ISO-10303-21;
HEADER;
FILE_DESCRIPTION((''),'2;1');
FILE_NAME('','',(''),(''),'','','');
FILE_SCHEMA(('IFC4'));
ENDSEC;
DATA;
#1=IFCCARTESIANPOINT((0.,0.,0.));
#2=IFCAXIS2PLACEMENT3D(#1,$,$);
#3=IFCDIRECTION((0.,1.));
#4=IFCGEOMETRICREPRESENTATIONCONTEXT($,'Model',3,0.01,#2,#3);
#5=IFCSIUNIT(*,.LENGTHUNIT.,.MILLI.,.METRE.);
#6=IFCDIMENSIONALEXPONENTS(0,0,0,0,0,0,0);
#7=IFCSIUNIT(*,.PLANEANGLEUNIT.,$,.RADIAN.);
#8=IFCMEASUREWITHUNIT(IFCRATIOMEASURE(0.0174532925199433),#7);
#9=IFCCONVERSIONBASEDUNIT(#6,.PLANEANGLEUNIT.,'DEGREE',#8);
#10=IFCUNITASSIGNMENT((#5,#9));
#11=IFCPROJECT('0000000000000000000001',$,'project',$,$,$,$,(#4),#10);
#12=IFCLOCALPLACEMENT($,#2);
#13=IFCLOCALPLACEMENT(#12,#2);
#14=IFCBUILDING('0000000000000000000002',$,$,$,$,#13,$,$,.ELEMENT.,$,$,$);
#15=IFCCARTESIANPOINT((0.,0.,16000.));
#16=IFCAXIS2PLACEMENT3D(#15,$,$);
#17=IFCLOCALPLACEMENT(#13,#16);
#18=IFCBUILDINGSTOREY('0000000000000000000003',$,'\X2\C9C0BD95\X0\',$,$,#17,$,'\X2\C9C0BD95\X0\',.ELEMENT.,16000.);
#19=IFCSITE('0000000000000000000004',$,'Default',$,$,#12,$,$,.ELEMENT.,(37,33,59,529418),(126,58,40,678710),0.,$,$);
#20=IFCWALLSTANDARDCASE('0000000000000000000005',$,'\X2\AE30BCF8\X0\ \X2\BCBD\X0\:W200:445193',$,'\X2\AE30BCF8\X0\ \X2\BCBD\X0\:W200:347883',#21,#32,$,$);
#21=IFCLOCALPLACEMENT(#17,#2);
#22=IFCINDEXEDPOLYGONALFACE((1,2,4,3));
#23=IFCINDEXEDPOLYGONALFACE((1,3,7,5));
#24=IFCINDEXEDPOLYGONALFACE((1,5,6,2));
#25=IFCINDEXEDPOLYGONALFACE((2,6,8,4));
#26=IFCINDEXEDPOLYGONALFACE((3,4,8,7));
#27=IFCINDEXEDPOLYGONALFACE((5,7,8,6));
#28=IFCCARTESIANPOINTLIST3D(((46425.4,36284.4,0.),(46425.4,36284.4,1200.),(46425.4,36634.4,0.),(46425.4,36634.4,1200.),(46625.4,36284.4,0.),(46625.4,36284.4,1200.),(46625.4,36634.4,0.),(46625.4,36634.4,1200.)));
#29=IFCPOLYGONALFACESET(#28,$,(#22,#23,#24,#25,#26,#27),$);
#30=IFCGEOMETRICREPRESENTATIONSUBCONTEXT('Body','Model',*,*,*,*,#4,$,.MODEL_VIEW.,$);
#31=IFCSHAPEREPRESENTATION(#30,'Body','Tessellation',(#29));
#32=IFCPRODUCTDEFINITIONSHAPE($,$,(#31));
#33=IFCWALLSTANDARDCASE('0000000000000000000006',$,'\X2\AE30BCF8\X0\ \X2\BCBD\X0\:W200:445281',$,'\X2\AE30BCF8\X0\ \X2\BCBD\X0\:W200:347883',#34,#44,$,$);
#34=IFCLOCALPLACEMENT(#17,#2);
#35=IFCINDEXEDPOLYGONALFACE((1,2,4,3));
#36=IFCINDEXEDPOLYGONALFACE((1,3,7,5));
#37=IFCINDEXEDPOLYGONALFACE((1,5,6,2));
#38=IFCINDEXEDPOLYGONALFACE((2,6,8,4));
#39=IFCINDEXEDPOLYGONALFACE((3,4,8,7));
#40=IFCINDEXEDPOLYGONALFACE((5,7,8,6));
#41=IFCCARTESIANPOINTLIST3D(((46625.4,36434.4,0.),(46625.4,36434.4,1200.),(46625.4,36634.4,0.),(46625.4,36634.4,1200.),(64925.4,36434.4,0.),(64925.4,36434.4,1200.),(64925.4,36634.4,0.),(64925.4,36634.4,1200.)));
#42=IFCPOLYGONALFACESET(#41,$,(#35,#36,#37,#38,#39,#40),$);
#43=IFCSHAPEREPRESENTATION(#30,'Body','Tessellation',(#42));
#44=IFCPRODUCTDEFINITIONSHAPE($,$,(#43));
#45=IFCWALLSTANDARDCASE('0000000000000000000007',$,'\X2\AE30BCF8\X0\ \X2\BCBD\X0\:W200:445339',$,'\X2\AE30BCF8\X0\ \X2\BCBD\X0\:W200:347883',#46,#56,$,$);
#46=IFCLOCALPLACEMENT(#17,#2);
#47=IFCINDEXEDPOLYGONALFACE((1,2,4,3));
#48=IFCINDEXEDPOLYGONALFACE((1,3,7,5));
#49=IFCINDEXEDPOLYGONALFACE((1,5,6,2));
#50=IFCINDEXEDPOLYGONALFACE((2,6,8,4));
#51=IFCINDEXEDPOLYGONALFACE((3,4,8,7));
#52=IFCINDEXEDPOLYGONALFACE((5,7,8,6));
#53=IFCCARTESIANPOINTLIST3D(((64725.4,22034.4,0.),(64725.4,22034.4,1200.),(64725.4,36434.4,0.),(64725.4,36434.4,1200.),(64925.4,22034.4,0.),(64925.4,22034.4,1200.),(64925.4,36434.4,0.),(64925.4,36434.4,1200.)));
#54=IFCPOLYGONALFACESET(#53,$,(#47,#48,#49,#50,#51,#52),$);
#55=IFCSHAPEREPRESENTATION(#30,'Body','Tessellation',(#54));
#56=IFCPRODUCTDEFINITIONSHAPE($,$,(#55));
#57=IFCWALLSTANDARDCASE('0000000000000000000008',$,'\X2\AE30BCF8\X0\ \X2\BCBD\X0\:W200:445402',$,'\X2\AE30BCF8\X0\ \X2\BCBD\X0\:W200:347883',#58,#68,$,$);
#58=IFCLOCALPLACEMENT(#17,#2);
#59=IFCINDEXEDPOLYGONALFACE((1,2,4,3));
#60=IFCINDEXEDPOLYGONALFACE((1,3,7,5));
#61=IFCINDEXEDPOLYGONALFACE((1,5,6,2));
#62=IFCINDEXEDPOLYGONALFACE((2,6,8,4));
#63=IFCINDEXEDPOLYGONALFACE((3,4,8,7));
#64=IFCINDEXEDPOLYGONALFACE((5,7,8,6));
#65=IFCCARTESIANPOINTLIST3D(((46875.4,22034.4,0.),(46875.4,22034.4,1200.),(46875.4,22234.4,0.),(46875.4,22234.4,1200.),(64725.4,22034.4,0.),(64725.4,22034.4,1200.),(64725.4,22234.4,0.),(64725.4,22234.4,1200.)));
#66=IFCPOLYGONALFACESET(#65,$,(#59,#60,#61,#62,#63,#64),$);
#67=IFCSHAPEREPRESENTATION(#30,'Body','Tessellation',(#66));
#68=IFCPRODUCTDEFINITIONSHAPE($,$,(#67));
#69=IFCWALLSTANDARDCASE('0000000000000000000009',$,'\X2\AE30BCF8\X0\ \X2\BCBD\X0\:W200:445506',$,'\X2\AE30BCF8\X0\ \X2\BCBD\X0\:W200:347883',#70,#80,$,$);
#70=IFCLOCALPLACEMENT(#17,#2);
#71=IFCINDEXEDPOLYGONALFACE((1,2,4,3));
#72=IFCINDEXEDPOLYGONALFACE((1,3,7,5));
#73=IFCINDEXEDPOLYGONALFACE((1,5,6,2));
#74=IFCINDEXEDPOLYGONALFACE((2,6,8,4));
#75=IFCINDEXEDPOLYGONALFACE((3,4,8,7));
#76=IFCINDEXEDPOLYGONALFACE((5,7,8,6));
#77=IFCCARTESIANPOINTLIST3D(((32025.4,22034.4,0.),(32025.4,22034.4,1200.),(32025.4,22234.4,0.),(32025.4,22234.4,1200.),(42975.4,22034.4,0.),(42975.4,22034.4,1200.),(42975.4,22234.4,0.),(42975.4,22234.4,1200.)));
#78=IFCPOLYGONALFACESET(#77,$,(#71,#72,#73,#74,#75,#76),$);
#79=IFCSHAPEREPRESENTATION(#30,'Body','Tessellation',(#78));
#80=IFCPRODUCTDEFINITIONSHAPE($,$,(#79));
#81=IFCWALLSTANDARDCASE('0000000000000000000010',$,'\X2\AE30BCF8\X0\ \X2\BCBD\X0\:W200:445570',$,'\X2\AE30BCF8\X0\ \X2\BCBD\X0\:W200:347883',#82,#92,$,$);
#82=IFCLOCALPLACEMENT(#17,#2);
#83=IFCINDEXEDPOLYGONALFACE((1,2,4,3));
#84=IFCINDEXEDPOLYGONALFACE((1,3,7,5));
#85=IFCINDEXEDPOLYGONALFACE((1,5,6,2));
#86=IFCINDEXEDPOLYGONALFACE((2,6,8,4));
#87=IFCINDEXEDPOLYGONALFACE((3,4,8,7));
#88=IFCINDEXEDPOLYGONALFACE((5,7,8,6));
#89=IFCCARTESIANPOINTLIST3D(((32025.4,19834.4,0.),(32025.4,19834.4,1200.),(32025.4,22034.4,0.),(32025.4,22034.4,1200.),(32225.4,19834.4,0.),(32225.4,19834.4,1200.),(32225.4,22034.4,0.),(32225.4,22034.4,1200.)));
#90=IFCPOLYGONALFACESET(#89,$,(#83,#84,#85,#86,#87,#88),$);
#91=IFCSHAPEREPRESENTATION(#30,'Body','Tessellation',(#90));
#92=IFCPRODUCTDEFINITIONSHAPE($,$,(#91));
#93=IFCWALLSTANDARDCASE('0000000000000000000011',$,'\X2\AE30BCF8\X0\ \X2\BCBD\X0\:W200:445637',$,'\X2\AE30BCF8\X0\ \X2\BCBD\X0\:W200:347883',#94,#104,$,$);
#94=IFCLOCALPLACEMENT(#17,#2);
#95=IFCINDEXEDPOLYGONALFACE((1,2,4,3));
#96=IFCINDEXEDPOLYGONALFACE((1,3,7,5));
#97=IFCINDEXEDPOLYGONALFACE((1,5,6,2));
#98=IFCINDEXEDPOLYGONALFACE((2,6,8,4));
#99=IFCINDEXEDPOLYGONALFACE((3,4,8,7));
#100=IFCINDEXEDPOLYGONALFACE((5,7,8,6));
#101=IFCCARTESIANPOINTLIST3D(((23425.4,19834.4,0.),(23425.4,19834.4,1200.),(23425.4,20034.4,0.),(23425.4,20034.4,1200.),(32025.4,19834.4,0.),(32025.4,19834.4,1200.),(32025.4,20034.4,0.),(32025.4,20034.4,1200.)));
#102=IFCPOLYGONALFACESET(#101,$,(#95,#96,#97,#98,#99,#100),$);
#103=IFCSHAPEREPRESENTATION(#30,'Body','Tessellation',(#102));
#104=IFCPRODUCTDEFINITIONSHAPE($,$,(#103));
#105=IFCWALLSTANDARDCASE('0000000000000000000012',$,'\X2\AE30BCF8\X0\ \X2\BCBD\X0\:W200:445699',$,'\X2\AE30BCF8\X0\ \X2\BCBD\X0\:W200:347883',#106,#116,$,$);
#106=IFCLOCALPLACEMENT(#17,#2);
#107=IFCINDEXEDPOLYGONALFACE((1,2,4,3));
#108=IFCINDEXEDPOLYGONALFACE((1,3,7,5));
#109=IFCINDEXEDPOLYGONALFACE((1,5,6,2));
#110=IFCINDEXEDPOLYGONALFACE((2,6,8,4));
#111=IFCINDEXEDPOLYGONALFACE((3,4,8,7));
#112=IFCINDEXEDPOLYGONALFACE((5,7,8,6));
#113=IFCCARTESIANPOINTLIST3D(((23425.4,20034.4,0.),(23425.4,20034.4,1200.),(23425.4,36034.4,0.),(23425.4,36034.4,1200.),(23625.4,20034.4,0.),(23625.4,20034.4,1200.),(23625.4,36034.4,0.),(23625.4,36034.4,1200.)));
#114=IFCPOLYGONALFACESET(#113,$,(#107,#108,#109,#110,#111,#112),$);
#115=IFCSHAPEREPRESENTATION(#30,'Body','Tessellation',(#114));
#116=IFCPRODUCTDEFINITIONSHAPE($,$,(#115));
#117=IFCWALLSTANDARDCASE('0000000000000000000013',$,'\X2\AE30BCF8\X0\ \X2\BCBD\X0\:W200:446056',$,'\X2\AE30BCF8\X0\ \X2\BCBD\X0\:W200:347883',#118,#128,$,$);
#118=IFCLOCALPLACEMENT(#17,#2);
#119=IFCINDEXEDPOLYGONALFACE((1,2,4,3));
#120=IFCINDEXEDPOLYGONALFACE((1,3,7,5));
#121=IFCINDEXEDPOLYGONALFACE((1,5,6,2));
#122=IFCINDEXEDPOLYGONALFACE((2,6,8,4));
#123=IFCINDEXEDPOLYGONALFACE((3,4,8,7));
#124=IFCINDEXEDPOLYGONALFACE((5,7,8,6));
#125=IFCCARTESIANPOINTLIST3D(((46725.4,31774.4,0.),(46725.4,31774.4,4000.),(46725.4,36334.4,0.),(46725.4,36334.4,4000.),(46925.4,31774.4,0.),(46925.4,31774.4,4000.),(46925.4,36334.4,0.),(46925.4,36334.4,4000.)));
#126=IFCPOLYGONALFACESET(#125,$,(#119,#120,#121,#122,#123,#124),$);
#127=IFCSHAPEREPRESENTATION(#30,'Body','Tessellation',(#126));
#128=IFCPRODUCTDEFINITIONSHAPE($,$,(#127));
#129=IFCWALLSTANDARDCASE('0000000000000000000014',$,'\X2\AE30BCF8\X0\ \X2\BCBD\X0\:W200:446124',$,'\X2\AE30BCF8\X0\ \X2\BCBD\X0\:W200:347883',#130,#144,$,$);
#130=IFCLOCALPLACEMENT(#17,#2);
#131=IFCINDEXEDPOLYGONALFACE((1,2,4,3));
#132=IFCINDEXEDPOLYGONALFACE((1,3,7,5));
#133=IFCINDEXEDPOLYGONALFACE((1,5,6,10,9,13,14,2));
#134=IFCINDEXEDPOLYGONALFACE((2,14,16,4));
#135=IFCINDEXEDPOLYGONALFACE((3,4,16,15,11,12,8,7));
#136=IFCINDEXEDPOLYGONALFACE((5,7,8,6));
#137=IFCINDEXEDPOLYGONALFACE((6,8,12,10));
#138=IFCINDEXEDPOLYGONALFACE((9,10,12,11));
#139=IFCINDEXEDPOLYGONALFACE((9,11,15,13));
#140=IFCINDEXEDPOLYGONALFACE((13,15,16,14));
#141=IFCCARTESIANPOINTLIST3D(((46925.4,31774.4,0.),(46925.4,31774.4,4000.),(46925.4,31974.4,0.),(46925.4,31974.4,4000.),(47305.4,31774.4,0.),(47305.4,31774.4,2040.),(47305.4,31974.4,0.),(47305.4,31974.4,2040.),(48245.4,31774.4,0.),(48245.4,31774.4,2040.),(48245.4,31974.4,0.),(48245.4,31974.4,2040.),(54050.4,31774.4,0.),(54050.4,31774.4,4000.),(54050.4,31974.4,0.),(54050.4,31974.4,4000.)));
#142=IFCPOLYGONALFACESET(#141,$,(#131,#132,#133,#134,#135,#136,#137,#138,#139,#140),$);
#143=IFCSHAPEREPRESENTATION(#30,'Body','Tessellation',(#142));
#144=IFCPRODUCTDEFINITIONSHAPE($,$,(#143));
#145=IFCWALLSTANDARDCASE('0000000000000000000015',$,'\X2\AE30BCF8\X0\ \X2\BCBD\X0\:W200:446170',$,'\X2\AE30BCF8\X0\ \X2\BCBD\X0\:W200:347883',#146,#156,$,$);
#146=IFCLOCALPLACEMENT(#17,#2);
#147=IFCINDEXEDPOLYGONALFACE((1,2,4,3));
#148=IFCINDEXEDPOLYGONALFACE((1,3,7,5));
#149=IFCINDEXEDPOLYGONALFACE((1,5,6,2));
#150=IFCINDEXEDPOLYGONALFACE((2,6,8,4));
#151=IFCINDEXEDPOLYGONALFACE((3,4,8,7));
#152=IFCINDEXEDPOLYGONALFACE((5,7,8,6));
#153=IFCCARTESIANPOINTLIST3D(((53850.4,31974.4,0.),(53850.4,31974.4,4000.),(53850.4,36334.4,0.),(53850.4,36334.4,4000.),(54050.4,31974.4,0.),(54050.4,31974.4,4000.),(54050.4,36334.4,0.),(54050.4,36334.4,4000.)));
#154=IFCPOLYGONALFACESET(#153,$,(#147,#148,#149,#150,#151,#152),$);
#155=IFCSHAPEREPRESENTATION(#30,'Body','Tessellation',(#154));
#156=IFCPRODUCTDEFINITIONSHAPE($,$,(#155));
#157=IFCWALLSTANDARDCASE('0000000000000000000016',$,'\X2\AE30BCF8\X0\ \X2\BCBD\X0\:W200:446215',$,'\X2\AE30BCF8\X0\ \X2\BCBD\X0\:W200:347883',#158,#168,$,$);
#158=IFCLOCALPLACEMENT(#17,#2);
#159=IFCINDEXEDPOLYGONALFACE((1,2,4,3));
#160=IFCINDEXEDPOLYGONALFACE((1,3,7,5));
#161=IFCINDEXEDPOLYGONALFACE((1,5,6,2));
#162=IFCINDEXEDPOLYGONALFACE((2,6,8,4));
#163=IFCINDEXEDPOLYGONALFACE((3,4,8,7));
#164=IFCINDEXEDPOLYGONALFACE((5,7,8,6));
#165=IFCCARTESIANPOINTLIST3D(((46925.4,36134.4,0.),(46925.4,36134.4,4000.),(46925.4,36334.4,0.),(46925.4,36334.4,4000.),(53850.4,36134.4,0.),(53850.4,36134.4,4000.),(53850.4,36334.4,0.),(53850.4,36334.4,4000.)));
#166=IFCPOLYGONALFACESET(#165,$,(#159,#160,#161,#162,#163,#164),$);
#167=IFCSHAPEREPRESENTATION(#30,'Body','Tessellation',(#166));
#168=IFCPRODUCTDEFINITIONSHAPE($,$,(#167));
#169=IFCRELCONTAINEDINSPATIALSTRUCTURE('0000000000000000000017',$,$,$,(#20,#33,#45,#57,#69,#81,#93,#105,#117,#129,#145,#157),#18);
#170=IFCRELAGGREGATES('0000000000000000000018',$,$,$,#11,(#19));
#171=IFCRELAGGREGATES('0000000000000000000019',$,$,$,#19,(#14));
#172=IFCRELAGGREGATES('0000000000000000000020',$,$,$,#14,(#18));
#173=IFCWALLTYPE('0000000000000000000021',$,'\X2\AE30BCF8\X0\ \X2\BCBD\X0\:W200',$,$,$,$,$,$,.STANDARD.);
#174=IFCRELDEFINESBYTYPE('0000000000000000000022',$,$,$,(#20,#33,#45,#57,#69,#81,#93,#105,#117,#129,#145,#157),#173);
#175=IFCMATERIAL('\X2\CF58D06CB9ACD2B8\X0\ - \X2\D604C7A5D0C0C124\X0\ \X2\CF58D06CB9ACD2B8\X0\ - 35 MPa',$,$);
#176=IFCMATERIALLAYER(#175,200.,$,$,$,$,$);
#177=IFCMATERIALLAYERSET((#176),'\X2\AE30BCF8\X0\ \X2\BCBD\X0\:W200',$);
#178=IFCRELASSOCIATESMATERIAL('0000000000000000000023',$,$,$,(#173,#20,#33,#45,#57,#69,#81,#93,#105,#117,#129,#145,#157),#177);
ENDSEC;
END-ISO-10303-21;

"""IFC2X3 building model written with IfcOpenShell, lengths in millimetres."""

from ifc_helpers import new_model, entity, si_unit, converted_unit, direction, frame, frame_2d, origin, place, context, subcontext, project, spatial, polyline, rectangle, extrude, clip, bounded_halfspace, material, layer, layer_set, layer_usage, type_object, element, save


model = new_model("IFC2X3")

# Units and contexts
model_context = context("Model", 3, precision=0.01, world=origin(), true_north=direction((0.0, 1.0)))
body_context = subcontext(model_context, "Body", "Model", "MODEL_VIEW")
ifc_project = project(units=[si_unit("LENGTHUNIT", "METRE", prefix="MILLI"), converted_unit("PLANEANGLEUNIT", "DEGREE", entity("IfcRatioMeasure", 0.0174532925199433), si_unit("PLANEANGLEUNIT", "RADIAN"), dimensions=[0, 0, 0, 0, 0, 0, 0])], contexts=[model_context])

# Site, building, storey
site_placement = place(None, origin())
site = spatial("IfcSite", under=ifc_project, at=site_placement, Name="Default", CompositionType="ELEMENT", RefLatitude=(37, 33, 59, 529418), RefLongitude=(126, 58, 40, 678710), RefElevation=0.0)
building_placement = place(site_placement, origin())
building = spatial("IfcBuilding", under=site, at=building_placement, CompositionType="ELEMENT")
storey_placement = place(building_placement, frame((0.0, 0.0, 16000.0)))
storey = spatial("IfcBuildingStorey", under=building, at=storey_placement, Name="지붕", LongName="지붕", CompositionType="ELEMENT", Elevation=16000.0)

# Walls
ifc_material_1 = material(Name="콘크리트 - 현장타설 콘크리트 - 35 MPa")
ifc_layer_1 = layer(ifc_material_1, 200.0)
ifc_layer_set_1 = layer_set([ifc_layer_1], Name="기본 벽:W200")
wall_type_1 = type_object("IfcWallType", Name="기본 벽:W200", PredefinedType="STANDARD", material=ifc_layer_set_1)
ifc_layer_usage_1 = layer_usage(ifc_layer_set_1, "AXIS2", "NEGATIVE", 100.0)
wall_1_placement = place(storey_placement, frame((46525.4, 36284.4, 0.0), z_axis=(0.0, 0.0, 1.0), x_axis=(0.0, 1.0, 0.0)))
element("IfcWallStandardCase", 1, at=wall_1_placement, inside=storey, type_object=wall_type_1, material=ifc_layer_usage_1, Name="기본 벽:W200:445193", ObjectType="기본 벽:W200:347883", context=body_context, shape_type="SweptSolid", body=[
    extrude(rectangle(XDim=350.0, YDim=200.0, at=frame_2d((175.0, 0.0), x_axis=(-1.0, 0.0))), origin(), (0.0, 0.0, 1.0), 1200.0),
])
ifc_layer_usage_2 = layer_usage(ifc_layer_set_1, "AXIS2", "NEGATIVE", 100.0)
wall_2_placement = place(storey_placement, frame((46625.4, 36534.4, 0.0)))
element("IfcWallStandardCase", 2, at=wall_2_placement, inside=storey, type_object=wall_type_1, material=ifc_layer_usage_2, Name="기본 벽:W200:445281", ObjectType="기본 벽:W200:347883", context=body_context, shape_type="SweptSolid", body=[
    extrude(rectangle(XDim=18300.0, YDim=200.0, at=frame_2d((9150.0, 0.0), x_axis=(-1.0, 0.0))), origin(), (0.0, 0.0, 1.0), 1200.0),
])
ifc_layer_usage_3 = layer_usage(ifc_layer_set_1, "AXIS2", "NEGATIVE", 100.0)
wall_3_placement = place(storey_placement, frame((64825.4, 36434.4, 0.0), z_axis=(0.0, 0.0, 1.0), x_axis=(0.0, -1.0, 0.0)))
element("IfcWallStandardCase", 3, at=wall_3_placement, inside=storey, type_object=wall_type_1, material=ifc_layer_usage_3, Name="기본 벽:W200:445339", ObjectType="기본 벽:W200:347883", context=body_context, shape_type="SweptSolid", body=[
    extrude(rectangle(XDim=14400.0, YDim=200.0, at=frame_2d((7200.0, 0.0), x_axis=(-1.0, 0.0))), origin(), (0.0, 0.0, 1.0), 1200.0),
])
ifc_layer_usage_4 = layer_usage(ifc_layer_set_1, "AXIS2", "NEGATIVE", 100.0)
wall_4_placement = place(storey_placement, frame((64725.4, 22134.4, 0.0), z_axis=(0.0, 0.0, 1.0), x_axis=(-1.0, 0.0, 0.0)))
element("IfcWallStandardCase", 4, at=wall_4_placement, inside=storey, type_object=wall_type_1, material=ifc_layer_usage_4, Name="기본 벽:W200:445402", ObjectType="기본 벽:W200:347883", context=body_context, shape_type="SweptSolid", body=[
    extrude(rectangle(XDim=17850.0, YDim=200.0, at=frame_2d((8925.0, 0.0), x_axis=(-1.0, 0.0))), origin(), (0.0, 0.0, 1.0), 1200.0),
])
ifc_layer_usage_5 = layer_usage(ifc_layer_set_1, "AXIS2", "NEGATIVE", 100.0)
wall_5_placement = place(storey_placement, frame((42975.4, 22134.4, 0.0), z_axis=(0.0, 0.0, 1.0), x_axis=(-1.0, 0.0, 0.0)))
element("IfcWallStandardCase", 5, at=wall_5_placement, inside=storey, type_object=wall_type_1, material=ifc_layer_usage_5, Name="기본 벽:W200:445506", ObjectType="기본 벽:W200:347883", context=body_context, shape_type="SweptSolid", body=[
    extrude(rectangle(XDim=10950.0, YDim=200.0, at=frame_2d((5475.0, 0.0), x_axis=(-1.0, 0.0))), origin(), (0.0, 0.0, 1.0), 1200.0),
])
ifc_layer_usage_6 = layer_usage(ifc_layer_set_1, "AXIS2", "NEGATIVE", 100.0)
wall_6_placement = place(storey_placement, frame((32125.4, 22034.4, 0.0), z_axis=(0.0, 0.0, 1.0), x_axis=(0.0, -1.0, 0.0)))
element("IfcWallStandardCase", 6, at=wall_6_placement, inside=storey, type_object=wall_type_1, material=ifc_layer_usage_6, Name="기본 벽:W200:445570", ObjectType="기본 벽:W200:347883", context=body_context, shape_type="SweptSolid", body=[
    extrude(rectangle(XDim=2200.0, YDim=200.0, at=frame_2d((1100.0, 0.0), x_axis=(-1.0, 0.0))), origin(), (0.0, 0.0, 1.0), 1200.0),
])
ifc_layer_usage_7 = layer_usage(ifc_layer_set_1, "AXIS2", "NEGATIVE", 100.0)
wall_7_placement = place(storey_placement, frame((32025.4, 19934.4, 0.0), z_axis=(0.0, 0.0, 1.0), x_axis=(-1.0, 0.0, 0.0)))
element("IfcWallStandardCase", 7, at=wall_7_placement, inside=storey, type_object=wall_type_1, material=ifc_layer_usage_7, Name="기본 벽:W200:445637", ObjectType="기본 벽:W200:347883", context=body_context, shape_type="SweptSolid", body=[
    extrude(rectangle(XDim=8600.0, YDim=200.0, at=frame_2d((4300.0, 0.0), x_axis=(-1.0, 0.0))), origin(), (0.0, 0.0, 1.0), 1200.0),
])
ifc_layer_usage_8 = layer_usage(ifc_layer_set_1, "AXIS2", "NEGATIVE", 100.0)
wall_8_placement = place(storey_placement, frame((23525.4, 20034.4, 0.0), z_axis=(0.0, 0.0, 1.0), x_axis=(0.0, 1.0, 0.0)))
element("IfcWallStandardCase", 8, at=wall_8_placement, inside=storey, type_object=wall_type_1, material=ifc_layer_usage_8, Name="기본 벽:W200:445699", ObjectType="기본 벽:W200:347883", context=body_context, shape_type="SweptSolid", body=[
    extrude(rectangle(XDim=16000.0, YDim=200.0, at=frame_2d((8000.0, 0.0), x_axis=(-1.0, 0.0))), origin(), (0.0, 0.0, 1.0), 1200.0),
])
ifc_layer_usage_9 = layer_usage(ifc_layer_set_1, "AXIS2", "NEGATIVE", 100.0)
wall_9_placement = place(storey_placement, frame((46825.4, 36334.4, 0.0), z_axis=(0.0, 0.0, 1.0), x_axis=(0.0, -1.0, 0.0)))
element("IfcWallStandardCase", 9, at=wall_9_placement, inside=storey, type_object=wall_type_1, material=ifc_layer_usage_9, Name="기본 벽:W200:446056", ObjectType="기본 벽:W200:347883", context=body_context, shape_type="Clipping", body=[
    clip(extrude(rectangle(XDim=4560.0, YDim=200.0, at=frame_2d((2280.0, 0.0), x_axis=(-1.0, 0.0))), origin(), (0.0, 0.0, 1.0), 4000.0), bounded_halfspace(frame((0.0, -100.0, 4000.0), z_axis=(0.0, 0.0, 1.0), x_axis=(0.0, 1.0, 0.0)), False, frame((0.0, -100.0, 4000.0)), polyline([(0.0, 0.0), (4560.0, 0.0), (4560.0, 200.0), (4360.0, 200.0), (200.0, 200.0), (0.0, 200.0), (0.0, 0.0)]))),
])

# Wall, opening
ifc_layer_usage_10 = layer_usage(ifc_layer_set_1, "AXIS2", "NEGATIVE", 100.0)
wall_10_placement = place(storey_placement, frame((46925.4, 31874.4, 0.0)))
wall_10 = element("IfcWallStandardCase", 10, at=wall_10_placement, inside=storey, type_object=wall_type_1, material=ifc_layer_usage_10, Name="기본 벽:W200:446124", ObjectType="기본 벽:W200:347883", context=body_context, shape_type="Clipping", body=[
    clip(extrude(rectangle(XDim=7125.0, YDim=200.0, at=frame_2d((3562.5, 0.0), x_axis=(-1.0, 0.0))), origin(), (0.0, 0.0, 1.0), 4000.0), bounded_halfspace(frame((0.0, -100.0, 4000.0)), False, frame((0.0, -100.0, 4000.0)), polyline([(0.0, 0.0), (7125.0, 0.0), (7125.0, 200.0), (6925.0, 200.0), (0.0, 200.0), (0.0, 0.0)]))),
])
opening_placement = place(wall_10_placement, frame((380.0, -100.0, 0.0)))
element("IfcOpeningElement", 11, at=opening_placement, cuts=wall_10, ObjectType="Opening", context=body_context, shape_type="SweptSolid", body=[
    extrude(rectangle(XDim=2040.0, YDim=940.0, at=frame_2d((1020.0, 470.0), x_axis=(1.0, 0.0))), frame((0.0, 0.0, 0.0), z_axis=(0.0, 1.0, 0.0), x_axis=(0.0, 0.0, 1.0)), (0.0, 0.0, 1.0), 200.0),
])

# Walls
ifc_layer_usage_11 = layer_usage(ifc_layer_set_1, "AXIS2", "NEGATIVE", 100.0)
wall_11_placement = place(storey_placement, frame((53950.4, 31974.4, 0.0), z_axis=(0.0, 0.0, 1.0), x_axis=(0.0, 1.0, 0.0)))
element("IfcWallStandardCase", 12, at=wall_11_placement, inside=storey, type_object=wall_type_1, material=ifc_layer_usage_11, Name="기본 벽:W200:446170", ObjectType="기본 벽:W200:347883", context=body_context, shape_type="Clipping", body=[
    clip(extrude(rectangle(XDim=4360.0, YDim=200.0, at=frame_2d((2180.0, 0.0), x_axis=(-1.0, 0.0))), origin(), (0.0, 0.0, 1.0), 4000.0), bounded_halfspace(frame((0.0, -100.0, 4000.0), z_axis=(0.0, 0.0, 1.0), x_axis=(0.0, -1.0, 0.0)), False, frame((0.0, -100.0, 4000.0)), polyline([(0.0, 0.0), (4360.0, 0.0), (4360.0, 200.0), (4160.0, 200.0), (0.0, 200.0), (0.0, 0.0)]))),
])
ifc_layer_usage_12 = layer_usage(ifc_layer_set_1, "AXIS2", "NEGATIVE", 100.0)
wall_12_placement = place(storey_placement, frame((53850.4, 36234.4, 0.0), z_axis=(0.0, 0.0, 1.0), x_axis=(-1.0, 0.0, 0.0)))
element("IfcWallStandardCase", 13, at=wall_12_placement, inside=storey, type_object=wall_type_1, material=ifc_layer_usage_12, Name="기본 벽:W200:446215", ObjectType="기본 벽:W200:347883", context=body_context, shape_type="Clipping", body=[
    clip(extrude(rectangle(XDim=6925.0, YDim=200.0, at=frame_2d((3462.5, 0.0), x_axis=(-1.0, 0.0))), origin(), (0.0, 0.0, 1.0), 4000.0), bounded_halfspace(frame((0.0, -100.0, 4000.0), z_axis=(0.0, 0.0, 1.0), x_axis=(-1.0, 0.0, 0.0)), False, frame((0.0, -100.0, 4000.0)), polyline([(0.0, 0.0), (6925.0, 0.0), (6925.0, 200.0), (0.0, 200.0), (0.0, 0.0)]))),
])

save(model, "model.ifc")
